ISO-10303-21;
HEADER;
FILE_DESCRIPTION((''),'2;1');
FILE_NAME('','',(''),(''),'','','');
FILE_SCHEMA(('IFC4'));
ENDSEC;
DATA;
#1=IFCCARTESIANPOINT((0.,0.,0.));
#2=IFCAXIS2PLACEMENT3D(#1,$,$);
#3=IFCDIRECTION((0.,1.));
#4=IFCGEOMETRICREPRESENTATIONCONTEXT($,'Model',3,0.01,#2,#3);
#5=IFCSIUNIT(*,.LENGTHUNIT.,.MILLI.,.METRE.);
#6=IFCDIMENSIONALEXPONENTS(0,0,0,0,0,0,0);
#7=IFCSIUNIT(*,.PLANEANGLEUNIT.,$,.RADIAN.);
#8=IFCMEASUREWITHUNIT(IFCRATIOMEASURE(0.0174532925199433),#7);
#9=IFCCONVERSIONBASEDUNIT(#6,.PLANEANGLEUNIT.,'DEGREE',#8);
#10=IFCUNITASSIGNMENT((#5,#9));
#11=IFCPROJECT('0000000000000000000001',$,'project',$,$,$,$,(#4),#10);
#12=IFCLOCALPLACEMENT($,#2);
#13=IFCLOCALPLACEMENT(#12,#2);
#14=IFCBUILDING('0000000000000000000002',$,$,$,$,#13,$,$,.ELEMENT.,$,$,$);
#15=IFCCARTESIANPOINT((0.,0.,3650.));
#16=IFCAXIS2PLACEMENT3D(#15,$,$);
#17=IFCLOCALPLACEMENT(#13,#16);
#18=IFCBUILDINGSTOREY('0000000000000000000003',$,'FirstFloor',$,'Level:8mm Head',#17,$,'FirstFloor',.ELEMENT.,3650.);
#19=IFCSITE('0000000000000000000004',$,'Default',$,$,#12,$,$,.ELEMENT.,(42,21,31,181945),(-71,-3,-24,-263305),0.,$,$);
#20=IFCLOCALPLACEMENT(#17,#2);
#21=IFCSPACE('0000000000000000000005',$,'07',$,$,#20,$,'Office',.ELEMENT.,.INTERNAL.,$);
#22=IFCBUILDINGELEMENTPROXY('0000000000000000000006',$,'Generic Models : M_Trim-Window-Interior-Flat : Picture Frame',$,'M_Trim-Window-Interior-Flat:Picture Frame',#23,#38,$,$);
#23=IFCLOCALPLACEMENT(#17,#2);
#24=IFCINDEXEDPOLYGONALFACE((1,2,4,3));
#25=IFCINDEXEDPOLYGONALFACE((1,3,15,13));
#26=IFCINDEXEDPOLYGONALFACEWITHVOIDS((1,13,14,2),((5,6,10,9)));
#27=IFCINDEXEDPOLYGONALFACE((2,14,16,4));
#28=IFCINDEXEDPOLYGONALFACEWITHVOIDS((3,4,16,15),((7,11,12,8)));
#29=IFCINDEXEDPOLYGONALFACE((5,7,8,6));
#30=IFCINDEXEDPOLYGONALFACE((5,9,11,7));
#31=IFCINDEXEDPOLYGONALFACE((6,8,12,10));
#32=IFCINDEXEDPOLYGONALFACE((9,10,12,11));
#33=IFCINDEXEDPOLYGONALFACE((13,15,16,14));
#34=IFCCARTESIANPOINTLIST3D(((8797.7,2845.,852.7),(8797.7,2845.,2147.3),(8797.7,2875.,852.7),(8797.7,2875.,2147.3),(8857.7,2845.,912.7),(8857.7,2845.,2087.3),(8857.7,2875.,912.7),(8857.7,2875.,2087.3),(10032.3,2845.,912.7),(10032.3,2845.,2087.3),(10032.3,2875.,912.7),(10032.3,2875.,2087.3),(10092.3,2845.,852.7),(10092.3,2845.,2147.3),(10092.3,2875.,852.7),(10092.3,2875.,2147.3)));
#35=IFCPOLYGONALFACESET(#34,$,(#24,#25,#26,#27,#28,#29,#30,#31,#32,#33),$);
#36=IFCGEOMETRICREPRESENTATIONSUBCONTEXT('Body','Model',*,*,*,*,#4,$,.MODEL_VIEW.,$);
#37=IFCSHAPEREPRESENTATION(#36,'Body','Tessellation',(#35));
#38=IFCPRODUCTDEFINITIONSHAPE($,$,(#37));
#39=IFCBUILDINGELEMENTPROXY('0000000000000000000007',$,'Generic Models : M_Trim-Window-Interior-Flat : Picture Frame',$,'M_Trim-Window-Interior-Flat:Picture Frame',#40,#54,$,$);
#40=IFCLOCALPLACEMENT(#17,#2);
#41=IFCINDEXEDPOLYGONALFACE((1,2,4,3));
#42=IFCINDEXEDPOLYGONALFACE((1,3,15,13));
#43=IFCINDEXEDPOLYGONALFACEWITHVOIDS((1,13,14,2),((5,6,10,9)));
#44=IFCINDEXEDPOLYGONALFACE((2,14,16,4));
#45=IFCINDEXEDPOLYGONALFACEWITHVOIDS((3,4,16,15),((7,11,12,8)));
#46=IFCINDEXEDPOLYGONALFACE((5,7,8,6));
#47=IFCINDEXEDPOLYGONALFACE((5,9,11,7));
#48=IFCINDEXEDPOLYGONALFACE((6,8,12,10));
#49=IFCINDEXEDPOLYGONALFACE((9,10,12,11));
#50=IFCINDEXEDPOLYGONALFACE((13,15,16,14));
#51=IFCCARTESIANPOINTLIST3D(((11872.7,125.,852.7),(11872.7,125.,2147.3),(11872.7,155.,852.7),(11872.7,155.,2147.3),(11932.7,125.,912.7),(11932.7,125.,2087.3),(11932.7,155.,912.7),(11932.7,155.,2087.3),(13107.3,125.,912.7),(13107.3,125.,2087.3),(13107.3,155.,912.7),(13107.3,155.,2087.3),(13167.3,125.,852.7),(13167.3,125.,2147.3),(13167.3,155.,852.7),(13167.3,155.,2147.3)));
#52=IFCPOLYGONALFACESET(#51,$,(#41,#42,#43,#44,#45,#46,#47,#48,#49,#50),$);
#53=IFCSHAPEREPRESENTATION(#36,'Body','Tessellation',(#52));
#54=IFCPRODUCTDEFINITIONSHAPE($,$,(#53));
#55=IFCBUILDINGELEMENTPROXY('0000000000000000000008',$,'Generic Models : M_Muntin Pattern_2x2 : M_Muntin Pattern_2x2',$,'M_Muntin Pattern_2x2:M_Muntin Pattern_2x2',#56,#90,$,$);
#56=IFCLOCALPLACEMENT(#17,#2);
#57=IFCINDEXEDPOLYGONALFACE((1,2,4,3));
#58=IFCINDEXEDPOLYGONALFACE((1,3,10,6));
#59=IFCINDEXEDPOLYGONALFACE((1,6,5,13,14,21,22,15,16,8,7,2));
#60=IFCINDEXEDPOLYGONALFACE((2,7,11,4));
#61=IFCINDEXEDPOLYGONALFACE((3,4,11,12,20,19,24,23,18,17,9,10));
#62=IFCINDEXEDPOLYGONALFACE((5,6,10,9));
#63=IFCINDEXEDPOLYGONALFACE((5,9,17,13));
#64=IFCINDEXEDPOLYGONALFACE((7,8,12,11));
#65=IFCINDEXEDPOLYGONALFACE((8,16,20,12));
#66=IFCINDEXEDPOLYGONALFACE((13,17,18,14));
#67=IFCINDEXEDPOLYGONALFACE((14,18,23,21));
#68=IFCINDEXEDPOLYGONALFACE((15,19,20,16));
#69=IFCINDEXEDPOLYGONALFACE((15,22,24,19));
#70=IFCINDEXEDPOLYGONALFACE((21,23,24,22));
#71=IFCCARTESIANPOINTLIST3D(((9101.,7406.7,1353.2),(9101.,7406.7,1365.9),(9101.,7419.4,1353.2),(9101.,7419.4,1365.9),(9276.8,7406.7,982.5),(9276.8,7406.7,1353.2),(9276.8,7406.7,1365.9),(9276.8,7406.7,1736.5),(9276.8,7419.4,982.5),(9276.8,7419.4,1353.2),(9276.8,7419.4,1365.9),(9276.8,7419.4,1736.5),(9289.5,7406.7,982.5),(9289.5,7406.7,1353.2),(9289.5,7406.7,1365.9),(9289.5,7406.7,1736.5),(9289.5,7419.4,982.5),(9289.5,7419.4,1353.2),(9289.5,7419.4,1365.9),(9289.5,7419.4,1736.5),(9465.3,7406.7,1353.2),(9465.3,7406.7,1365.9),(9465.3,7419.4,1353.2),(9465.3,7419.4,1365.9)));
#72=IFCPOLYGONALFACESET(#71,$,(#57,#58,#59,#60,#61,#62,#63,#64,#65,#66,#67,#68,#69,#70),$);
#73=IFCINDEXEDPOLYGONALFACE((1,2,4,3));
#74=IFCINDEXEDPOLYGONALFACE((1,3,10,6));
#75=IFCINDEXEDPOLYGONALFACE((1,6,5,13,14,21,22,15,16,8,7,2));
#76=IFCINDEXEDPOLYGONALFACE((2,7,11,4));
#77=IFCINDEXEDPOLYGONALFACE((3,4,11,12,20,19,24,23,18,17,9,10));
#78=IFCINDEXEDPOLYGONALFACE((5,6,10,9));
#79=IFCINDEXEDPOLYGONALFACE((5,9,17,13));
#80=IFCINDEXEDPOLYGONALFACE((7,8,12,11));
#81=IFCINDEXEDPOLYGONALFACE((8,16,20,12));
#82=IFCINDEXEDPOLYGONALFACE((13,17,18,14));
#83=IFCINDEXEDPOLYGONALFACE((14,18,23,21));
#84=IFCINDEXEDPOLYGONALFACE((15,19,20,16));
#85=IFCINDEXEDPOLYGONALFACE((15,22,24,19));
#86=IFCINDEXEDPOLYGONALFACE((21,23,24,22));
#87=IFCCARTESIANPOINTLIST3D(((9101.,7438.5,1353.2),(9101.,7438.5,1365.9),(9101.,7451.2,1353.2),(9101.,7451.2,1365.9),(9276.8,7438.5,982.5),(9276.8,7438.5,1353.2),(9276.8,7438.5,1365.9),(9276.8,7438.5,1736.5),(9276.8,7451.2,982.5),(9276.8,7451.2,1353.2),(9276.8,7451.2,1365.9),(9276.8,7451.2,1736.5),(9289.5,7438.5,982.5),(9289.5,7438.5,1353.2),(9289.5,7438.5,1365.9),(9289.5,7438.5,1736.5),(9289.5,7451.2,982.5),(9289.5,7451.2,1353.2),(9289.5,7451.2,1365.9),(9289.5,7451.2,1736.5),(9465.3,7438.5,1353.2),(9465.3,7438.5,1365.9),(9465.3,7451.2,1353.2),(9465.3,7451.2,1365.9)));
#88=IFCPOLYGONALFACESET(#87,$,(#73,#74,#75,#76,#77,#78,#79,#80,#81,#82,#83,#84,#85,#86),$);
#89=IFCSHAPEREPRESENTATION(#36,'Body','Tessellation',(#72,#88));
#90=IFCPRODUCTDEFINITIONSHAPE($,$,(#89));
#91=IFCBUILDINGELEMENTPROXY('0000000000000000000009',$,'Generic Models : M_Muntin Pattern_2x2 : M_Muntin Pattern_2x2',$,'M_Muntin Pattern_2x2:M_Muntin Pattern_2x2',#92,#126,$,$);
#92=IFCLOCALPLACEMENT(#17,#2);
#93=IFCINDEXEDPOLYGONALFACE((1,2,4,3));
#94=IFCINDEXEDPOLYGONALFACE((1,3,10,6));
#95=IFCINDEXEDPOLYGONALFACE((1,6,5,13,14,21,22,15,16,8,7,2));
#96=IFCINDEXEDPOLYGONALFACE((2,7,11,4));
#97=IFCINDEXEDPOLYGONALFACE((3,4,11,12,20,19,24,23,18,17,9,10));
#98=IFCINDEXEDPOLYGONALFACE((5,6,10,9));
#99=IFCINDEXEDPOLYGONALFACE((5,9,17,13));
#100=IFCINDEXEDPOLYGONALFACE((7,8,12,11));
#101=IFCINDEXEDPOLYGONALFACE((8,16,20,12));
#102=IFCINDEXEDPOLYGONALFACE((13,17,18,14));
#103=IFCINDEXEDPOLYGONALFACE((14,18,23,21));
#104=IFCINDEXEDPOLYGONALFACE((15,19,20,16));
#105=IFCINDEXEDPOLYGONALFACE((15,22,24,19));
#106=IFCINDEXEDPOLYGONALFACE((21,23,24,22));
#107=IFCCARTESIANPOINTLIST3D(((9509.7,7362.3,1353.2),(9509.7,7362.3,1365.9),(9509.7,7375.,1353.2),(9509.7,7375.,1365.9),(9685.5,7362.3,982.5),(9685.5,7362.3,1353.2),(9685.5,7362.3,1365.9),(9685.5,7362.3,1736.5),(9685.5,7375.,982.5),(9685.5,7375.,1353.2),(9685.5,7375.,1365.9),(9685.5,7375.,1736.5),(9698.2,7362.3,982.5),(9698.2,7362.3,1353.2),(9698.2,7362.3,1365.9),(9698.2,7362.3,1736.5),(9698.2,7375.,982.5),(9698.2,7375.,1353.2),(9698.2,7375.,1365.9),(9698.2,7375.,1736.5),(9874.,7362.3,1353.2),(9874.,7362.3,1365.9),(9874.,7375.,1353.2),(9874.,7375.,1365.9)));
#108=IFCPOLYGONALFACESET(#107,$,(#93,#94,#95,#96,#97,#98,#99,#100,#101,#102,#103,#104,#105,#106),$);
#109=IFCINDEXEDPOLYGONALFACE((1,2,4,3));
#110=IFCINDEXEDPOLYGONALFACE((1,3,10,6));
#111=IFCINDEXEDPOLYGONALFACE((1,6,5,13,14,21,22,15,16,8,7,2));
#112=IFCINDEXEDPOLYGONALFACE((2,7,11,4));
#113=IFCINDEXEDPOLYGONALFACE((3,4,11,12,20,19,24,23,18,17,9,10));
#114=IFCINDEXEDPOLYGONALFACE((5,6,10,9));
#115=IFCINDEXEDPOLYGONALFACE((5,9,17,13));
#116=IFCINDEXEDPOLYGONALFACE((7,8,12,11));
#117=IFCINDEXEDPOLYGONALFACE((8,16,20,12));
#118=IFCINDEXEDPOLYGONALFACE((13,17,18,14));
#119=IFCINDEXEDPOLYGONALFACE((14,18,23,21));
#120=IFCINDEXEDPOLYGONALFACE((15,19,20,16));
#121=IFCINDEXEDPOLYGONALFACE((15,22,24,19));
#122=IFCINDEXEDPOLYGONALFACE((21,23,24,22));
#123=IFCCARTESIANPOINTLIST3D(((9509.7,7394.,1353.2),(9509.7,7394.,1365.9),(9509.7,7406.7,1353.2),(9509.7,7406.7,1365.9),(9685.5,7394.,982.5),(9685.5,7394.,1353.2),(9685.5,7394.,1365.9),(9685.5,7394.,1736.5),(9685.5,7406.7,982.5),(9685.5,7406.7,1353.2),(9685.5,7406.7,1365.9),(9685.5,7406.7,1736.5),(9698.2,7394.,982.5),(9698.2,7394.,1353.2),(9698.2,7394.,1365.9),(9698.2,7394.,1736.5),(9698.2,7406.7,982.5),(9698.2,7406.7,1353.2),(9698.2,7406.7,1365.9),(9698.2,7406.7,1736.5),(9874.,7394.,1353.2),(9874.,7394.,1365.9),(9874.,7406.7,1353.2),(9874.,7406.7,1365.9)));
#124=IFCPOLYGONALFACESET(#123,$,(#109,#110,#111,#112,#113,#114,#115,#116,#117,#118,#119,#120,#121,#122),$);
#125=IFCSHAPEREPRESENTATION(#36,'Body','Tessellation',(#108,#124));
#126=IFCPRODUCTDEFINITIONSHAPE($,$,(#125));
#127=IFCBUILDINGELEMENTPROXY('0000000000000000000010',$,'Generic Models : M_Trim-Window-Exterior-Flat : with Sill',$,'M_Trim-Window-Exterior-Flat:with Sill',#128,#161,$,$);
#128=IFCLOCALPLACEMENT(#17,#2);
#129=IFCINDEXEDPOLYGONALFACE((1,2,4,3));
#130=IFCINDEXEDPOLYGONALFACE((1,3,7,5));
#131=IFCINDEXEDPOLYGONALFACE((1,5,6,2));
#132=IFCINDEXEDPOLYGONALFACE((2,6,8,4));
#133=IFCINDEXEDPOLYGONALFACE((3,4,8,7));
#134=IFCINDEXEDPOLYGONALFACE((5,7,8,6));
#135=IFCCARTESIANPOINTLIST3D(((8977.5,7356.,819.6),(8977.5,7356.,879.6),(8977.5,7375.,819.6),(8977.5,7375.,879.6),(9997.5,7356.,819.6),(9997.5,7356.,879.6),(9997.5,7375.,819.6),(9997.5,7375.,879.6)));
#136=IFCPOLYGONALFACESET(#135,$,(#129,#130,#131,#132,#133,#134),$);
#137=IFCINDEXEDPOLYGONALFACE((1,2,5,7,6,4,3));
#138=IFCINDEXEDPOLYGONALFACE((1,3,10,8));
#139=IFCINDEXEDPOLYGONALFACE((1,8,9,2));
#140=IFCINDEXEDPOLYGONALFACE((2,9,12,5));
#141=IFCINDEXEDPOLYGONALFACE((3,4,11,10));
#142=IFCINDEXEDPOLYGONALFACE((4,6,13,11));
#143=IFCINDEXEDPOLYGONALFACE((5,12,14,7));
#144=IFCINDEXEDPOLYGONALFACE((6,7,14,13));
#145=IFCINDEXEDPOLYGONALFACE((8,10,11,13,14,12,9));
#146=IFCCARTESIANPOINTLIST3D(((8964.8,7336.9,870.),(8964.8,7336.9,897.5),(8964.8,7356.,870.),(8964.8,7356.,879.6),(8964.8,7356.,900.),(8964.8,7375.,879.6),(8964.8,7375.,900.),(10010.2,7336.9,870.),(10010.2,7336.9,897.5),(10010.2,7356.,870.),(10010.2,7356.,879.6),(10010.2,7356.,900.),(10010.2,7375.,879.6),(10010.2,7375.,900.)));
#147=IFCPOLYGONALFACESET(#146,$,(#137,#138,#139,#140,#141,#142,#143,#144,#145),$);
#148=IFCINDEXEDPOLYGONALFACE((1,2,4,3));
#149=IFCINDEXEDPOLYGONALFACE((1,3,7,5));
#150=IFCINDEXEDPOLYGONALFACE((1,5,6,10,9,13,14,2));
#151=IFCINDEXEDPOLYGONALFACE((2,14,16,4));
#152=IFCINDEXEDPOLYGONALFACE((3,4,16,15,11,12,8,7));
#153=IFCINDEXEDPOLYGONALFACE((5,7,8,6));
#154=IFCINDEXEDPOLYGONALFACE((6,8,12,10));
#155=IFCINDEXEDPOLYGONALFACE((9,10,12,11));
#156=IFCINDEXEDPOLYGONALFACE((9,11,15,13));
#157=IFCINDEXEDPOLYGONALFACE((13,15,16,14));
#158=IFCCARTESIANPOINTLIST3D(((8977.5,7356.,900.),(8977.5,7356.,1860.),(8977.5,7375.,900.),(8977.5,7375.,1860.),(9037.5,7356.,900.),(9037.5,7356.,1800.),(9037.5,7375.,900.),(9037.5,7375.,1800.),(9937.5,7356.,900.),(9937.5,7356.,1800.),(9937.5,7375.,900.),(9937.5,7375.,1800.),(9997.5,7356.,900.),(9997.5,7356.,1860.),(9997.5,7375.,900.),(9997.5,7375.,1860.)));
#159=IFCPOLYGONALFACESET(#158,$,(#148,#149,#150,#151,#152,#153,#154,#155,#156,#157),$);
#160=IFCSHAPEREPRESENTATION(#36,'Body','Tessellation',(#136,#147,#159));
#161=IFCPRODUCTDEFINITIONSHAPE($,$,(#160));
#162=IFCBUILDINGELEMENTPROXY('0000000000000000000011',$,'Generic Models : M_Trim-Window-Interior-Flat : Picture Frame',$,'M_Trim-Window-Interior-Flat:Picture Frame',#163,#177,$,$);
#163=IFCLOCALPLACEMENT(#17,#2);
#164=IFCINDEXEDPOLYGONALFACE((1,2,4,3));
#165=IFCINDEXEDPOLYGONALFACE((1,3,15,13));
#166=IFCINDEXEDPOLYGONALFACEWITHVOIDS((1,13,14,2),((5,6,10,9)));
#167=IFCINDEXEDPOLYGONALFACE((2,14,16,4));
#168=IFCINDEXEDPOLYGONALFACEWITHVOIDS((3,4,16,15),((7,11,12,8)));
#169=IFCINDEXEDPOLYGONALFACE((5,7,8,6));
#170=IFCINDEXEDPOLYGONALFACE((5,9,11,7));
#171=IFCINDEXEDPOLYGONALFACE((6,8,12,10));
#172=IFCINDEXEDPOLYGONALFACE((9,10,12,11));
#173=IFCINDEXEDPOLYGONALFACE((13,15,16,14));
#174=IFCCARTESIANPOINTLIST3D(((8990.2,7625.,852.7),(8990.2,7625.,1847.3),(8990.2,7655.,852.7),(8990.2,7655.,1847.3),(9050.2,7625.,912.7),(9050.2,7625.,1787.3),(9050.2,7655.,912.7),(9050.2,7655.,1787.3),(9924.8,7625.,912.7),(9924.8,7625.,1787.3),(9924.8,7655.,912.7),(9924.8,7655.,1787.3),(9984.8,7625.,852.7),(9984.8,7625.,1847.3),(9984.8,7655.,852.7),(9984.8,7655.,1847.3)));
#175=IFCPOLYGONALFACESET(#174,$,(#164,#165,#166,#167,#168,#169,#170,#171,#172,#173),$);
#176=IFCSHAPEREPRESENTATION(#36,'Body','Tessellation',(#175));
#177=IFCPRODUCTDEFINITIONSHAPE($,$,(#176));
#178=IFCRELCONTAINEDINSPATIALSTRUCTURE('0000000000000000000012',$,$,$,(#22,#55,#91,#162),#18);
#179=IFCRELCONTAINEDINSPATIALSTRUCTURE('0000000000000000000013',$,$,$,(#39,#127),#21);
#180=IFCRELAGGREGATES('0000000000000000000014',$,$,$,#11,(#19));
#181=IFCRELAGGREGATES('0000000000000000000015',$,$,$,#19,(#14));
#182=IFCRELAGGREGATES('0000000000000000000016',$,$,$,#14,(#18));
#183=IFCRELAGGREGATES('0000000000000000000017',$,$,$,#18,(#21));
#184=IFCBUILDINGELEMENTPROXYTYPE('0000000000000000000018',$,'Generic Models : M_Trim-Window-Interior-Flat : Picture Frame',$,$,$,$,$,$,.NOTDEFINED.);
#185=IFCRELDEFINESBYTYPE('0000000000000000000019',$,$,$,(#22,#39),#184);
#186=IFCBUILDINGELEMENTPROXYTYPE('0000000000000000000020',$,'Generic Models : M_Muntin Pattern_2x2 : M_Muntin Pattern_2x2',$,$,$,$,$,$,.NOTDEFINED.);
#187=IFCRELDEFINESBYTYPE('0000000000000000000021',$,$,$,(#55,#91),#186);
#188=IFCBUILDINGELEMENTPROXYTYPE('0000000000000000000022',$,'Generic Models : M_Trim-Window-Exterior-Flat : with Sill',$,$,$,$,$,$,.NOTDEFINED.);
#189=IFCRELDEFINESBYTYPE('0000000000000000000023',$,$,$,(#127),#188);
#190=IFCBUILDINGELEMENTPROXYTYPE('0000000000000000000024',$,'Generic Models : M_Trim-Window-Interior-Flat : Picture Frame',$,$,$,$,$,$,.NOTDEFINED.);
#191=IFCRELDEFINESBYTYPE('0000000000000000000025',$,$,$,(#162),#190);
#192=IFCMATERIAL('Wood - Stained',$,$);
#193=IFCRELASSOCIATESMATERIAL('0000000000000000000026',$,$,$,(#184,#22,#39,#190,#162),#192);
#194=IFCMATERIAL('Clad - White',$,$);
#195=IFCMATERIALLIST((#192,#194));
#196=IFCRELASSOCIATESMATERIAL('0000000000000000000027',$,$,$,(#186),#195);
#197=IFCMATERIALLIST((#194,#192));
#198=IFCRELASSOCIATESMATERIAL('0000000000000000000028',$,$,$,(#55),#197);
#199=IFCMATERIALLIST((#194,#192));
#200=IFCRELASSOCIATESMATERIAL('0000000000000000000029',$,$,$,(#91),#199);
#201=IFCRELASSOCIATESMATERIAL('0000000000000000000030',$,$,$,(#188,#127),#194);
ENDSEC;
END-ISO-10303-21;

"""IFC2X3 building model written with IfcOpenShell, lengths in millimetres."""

from ifc_helpers import new_model, entity, si_unit, converted_unit, direction, frame, frame_2d, origin, place, context, subcontext, project, spatial, polyline, rectangle, outline, extrude, source, transform, mapped, material, material_list, type_object, type_shapes, element, save


model = new_model("IFC2X3")

# Units and contexts
model_context = context("Model", 3, precision=0.01, world=origin(), true_north=direction((0.0, 1.0)))
body_context = subcontext(model_context, "Body", "Model", "MODEL_VIEW")
ifc_project = project(units=[si_unit("LENGTHUNIT", "METRE", prefix="MILLI"), converted_unit("PLANEANGLEUNIT", "DEGREE", entity("IfcRatioMeasure", 0.0174532925199433), si_unit("PLANEANGLEUNIT", "RADIAN"), dimensions=[0, 0, 0, 0, 0, 0, 0])], contexts=[model_context])

# Site, building, storey
site_placement = place(None, origin())
site = spatial("IfcSite", under=ifc_project, at=site_placement, Name="Default", CompositionType="ELEMENT", RefLatitude=(42, 21, 31, 181945), RefLongitude=(-71, -3, -24, -263305), RefElevation=0.0)
building_placement = place(site_placement, origin())
building = spatial("IfcBuilding", under=site, at=building_placement, CompositionType="ELEMENT")
storey_placement = place(building_placement, frame((0.0, 0.0, 3650.0)))
storey = spatial("IfcBuildingStorey", under=building, at=storey_placement, Name="FirstFloor", ObjectType="Level:8mm Head", LongName="FirstFloor", CompositionType="ELEMENT", Elevation=3650.0)

# Shared definitions
ifc_material_1 = material(Name="Clad - White")
ifc_material_2 = material(Name="Wood - Stained")

# Shared definitions
space_placement = place(storey_placement, origin())
space = spatial("IfcSpace", under=storey, at=space_placement, Name="07", LongName="Office", CompositionType="ELEMENT", InteriorOrExteriorSpace="INTERNAL")

# Building element proxies
building_element_proxy_type_1 = type_object("IfcBuildingElementProxyType", Name="Generic Models : M_Trim-Window-Interior-Flat : Picture Frame", PredefinedType="NOTDEFINED", material=ifc_material_2)
shared_shape_1 = source(origin(), body_context, "Body", "SweptSolid", [
    extrude(outline(polyline([(-647.3, -647.3), (647.3, -647.3), (647.3, 647.3), (-647.3, 647.3), (-647.3, -647.3)]), holes=[polyline([(-587.3, -587.3), (-587.3, 587.3), (587.3, 587.3), (587.3, -587.3), (-587.3, -587.3)])]), frame((0.0, -600.0, 0.0), z_axis=(0.0, 0.0, 1.0), x_axis=(-1.0, 0.0, 0.0)), (0.0, 0.0, 1.0), 30.0),
])
type_shapes(building_element_proxy_type_1, [shared_shape_1])
proxy_1_placement = place(storey_placement, frame((9445.0, 2875.0, 2100.0), z_axis=(0.0, -1.0, 0.0), x_axis=(1.0, 0.0, 0.0)))
element("IfcBuildingElementProxy", 1, at=proxy_1_placement, inside=storey, type_object=building_element_proxy_type_1, material=ifc_material_2, Name="Generic Models : M_Trim-Window-Interior-Flat : Picture Frame", ObjectType="M_Trim-Window-Interior-Flat:Picture Frame", context=body_context, shape_type="MappedRepresentation", body=[
    mapped(shared_shape_1, transform((0.0, 0.0, 0.0), scale=1.0)),
])
proxy_2_placement = place(space_placement, frame((12520.0, 125.0, 2100.0), z_axis=(0.0, 1.0, 0.0), x_axis=(-1.0, 0.0, 0.0)))
element("IfcBuildingElementProxy", 2, at=proxy_2_placement, inside=space, type_object=building_element_proxy_type_1, material=ifc_material_2, Name="Generic Models : M_Trim-Window-Interior-Flat : Picture Frame", ObjectType="M_Trim-Window-Interior-Flat:Picture Frame", context=body_context, shape_type="MappedRepresentation", body=[
    mapped(shared_shape_1, transform((0.0, 0.0, 0.0), scale=1.0)),
])
ifc_material_list_1 = material_list([ifc_material_1, ifc_material_2])
ifc_material_list_2 = material_list([ifc_material_2, ifc_material_1])
building_element_proxy_type_2 = type_object("IfcBuildingElementProxyType", Name="Generic Models : M_Muntin Pattern_2x2 : M_Muntin Pattern_2x2", PredefinedType="NOTDEFINED", material=ifc_material_list_2)
shared_shape_2 = source(origin(), body_context, "Body", "SweptSolid", [
    extrude(outline(polyline([(6.4, -6.4), (377.0, -6.4), (377.0, 6.3), (6.4, 6.3), (6.4, 182.1), (-6.3, 182.1), (-6.3, 6.3), (-377.0, 6.3), (-377.0, -6.4), (-6.3, -6.4), (-6.3, -182.1), (6.4, -182.1), (6.4, -6.4)])), frame((0.0, 9.5, 377.0), z_axis=(0.0, 1.0, 0.0), x_axis=(0.0, 0.0, 1.0)), (0.0, 0.0, 1.0), 12.7),
    extrude(outline(polyline([(6.4, -6.4), (377.0, -6.4), (377.0, 6.3), (6.4, 6.3), (6.4, 182.1), (-6.3, 182.1), (-6.3, 6.3), (-377.0, 6.3), (-377.0, -6.4), (-6.3, -6.4), (-6.3, -182.1), (6.4, -182.1), (6.4, -6.4)])), frame((0.0, -22.2, 377.0), z_axis=(0.0, 1.0, 0.0), x_axis=(0.0, 0.0, 1.0)), (0.0, 0.0, 1.0), 12.7),
])
type_shapes(building_element_proxy_type_2, [shared_shape_2])
proxy_3_placement = place(storey_placement, frame((9283.1, 7429.0, 982.5), z_axis=(0.0, 0.0, 1.0), x_axis=(-1.0, 0.0, 0.0)))
element("IfcBuildingElementProxy", 3, at=proxy_3_placement, inside=storey, type_object=building_element_proxy_type_2, material=ifc_material_list_1, Name="Generic Models : M_Muntin Pattern_2x2 : M_Muntin Pattern_2x2", ObjectType="M_Muntin Pattern_2x2:M_Muntin Pattern_2x2", context=body_context, shape_type="MappedRepresentation", body=[
    mapped(shared_shape_2, transform((0.0, 0.0, 0.0), scale=1.0)),
])
ifc_material_list_3 = material_list([ifc_material_1, ifc_material_2])
proxy_4_placement = place(storey_placement, frame((9691.9, 7384.5, 982.5), z_axis=(0.0, 0.0, 1.0), x_axis=(-1.0, 0.0, 0.0)))
element("IfcBuildingElementProxy", 4, at=proxy_4_placement, inside=storey, type_object=building_element_proxy_type_2, material=ifc_material_list_3, Name="Generic Models : M_Muntin Pattern_2x2 : M_Muntin Pattern_2x2", ObjectType="M_Muntin Pattern_2x2:M_Muntin Pattern_2x2", context=body_context, shape_type="MappedRepresentation", body=[
    mapped(shared_shape_2, transform((0.0, 0.0, 0.0), scale=1.0)),
])
building_element_proxy_type_3 = type_object("IfcBuildingElementProxyType", Name="Generic Models : M_Trim-Window-Exterior-Flat : with Sill", PredefinedType="NOTDEFINED", material=ifc_material_1)
shared_shape_3 = source(origin(), body_context, "Body", "SweptSolid", [
    extrude(rectangle(XDim=1020.0, YDim=60.0, at=frame_2d((0.0, 0.0), x_axis=(1.0, 0.0))), frame((0.0, -950.4, 0.0), z_axis=(0.0, 0.0, 1.0), x_axis=(-1.0, 0.0, 0.0)), (0.0, 0.0, 1.0), 19.1),
    extrude(outline(polyline([(-19.0, -15.2), (0.0, -15.2), (0.0, -5.7), (19.0, -5.7), (19.0, 14.8), (0.0, 14.8), (-19.0, 12.3), (-19.0, -15.2)])), frame((-522.7, -914.8, 19.0), z_axis=(1.0, 0.0, 0.0), x_axis=(0.0, 0.0, -1.0)), (0.0, 0.0, 1.0), 1045.4),
    extrude(outline(polyline([(-495.0, -510.0), (465.0, -510.0), (465.0, -450.0), (-435.0, -450.0), (-435.0, 450.0), (465.0, 450.0), (465.0, 510.0), (-495.0, 510.0), (-495.0, -510.0)])), frame((0.0, -435.0, 0.0), z_axis=(0.0, 0.0, 1.0), x_axis=(0.0, -1.0, 0.0)), (0.0, 0.0, 1.0), 19.1),
])
type_shapes(building_element_proxy_type_3, [shared_shape_3])
proxy_5_placement = place(space_placement, frame((9487.5, 7375.0, 1800.0), z_axis=(0.0, -1.0, 0.0), x_axis=(1.0, 0.0, 0.0)))
element("IfcBuildingElementProxy", 5, at=proxy_5_placement, inside=space, type_object=building_element_proxy_type_3, material=ifc_material_1, Name="Generic Models : M_Trim-Window-Exterior-Flat : with Sill", ObjectType="M_Trim-Window-Exterior-Flat:with Sill", context=body_context, shape_type="MappedRepresentation", body=[
    mapped(shared_shape_3, transform((0.0, 0.0, 0.0), scale=1.0)),
])
building_element_proxy_type_4 = type_object("IfcBuildingElementProxyType", Name="Generic Models : M_Trim-Window-Interior-Flat : Picture Frame", PredefinedType="NOTDEFINED", material=ifc_material_2)
shared_shape_4 = source(origin(), body_context, "Body", "SweptSolid", [
    extrude(outline(polyline([(-497.3, -497.3), (497.3, -497.3), (497.3, 497.3), (-497.3, 497.3), (-497.3, -497.3)]), holes=[polyline([(-437.3, -437.3), (-437.3, 437.3), (437.3, 437.3), (437.3, -437.3), (-437.3, -437.3)])]), frame((0.0, -450.0, 0.0), z_axis=(0.0, 0.0, 1.0), x_axis=(-1.0, 0.0, 0.0)), (0.0, 0.0, 1.0), 30.0),
])
type_shapes(building_element_proxy_type_4, [shared_shape_4])
proxy_6_placement = place(storey_placement, frame((9487.5, 7625.0, 1800.0), z_axis=(0.0, 1.0, 0.0), x_axis=(-1.0, 0.0, 0.0)))
element("IfcBuildingElementProxy", 6, at=proxy_6_placement, inside=storey, type_object=building_element_proxy_type_4, material=ifc_material_2, Name="Generic Models : M_Trim-Window-Interior-Flat : Picture Frame", ObjectType="M_Trim-Window-Interior-Flat:Picture Frame", context=body_context, shape_type="MappedRepresentation", body=[
    mapped(shared_shape_4, transform((0.0, 0.0, 0.0), scale=1.0)),
])

save(model, "model.ifc")
